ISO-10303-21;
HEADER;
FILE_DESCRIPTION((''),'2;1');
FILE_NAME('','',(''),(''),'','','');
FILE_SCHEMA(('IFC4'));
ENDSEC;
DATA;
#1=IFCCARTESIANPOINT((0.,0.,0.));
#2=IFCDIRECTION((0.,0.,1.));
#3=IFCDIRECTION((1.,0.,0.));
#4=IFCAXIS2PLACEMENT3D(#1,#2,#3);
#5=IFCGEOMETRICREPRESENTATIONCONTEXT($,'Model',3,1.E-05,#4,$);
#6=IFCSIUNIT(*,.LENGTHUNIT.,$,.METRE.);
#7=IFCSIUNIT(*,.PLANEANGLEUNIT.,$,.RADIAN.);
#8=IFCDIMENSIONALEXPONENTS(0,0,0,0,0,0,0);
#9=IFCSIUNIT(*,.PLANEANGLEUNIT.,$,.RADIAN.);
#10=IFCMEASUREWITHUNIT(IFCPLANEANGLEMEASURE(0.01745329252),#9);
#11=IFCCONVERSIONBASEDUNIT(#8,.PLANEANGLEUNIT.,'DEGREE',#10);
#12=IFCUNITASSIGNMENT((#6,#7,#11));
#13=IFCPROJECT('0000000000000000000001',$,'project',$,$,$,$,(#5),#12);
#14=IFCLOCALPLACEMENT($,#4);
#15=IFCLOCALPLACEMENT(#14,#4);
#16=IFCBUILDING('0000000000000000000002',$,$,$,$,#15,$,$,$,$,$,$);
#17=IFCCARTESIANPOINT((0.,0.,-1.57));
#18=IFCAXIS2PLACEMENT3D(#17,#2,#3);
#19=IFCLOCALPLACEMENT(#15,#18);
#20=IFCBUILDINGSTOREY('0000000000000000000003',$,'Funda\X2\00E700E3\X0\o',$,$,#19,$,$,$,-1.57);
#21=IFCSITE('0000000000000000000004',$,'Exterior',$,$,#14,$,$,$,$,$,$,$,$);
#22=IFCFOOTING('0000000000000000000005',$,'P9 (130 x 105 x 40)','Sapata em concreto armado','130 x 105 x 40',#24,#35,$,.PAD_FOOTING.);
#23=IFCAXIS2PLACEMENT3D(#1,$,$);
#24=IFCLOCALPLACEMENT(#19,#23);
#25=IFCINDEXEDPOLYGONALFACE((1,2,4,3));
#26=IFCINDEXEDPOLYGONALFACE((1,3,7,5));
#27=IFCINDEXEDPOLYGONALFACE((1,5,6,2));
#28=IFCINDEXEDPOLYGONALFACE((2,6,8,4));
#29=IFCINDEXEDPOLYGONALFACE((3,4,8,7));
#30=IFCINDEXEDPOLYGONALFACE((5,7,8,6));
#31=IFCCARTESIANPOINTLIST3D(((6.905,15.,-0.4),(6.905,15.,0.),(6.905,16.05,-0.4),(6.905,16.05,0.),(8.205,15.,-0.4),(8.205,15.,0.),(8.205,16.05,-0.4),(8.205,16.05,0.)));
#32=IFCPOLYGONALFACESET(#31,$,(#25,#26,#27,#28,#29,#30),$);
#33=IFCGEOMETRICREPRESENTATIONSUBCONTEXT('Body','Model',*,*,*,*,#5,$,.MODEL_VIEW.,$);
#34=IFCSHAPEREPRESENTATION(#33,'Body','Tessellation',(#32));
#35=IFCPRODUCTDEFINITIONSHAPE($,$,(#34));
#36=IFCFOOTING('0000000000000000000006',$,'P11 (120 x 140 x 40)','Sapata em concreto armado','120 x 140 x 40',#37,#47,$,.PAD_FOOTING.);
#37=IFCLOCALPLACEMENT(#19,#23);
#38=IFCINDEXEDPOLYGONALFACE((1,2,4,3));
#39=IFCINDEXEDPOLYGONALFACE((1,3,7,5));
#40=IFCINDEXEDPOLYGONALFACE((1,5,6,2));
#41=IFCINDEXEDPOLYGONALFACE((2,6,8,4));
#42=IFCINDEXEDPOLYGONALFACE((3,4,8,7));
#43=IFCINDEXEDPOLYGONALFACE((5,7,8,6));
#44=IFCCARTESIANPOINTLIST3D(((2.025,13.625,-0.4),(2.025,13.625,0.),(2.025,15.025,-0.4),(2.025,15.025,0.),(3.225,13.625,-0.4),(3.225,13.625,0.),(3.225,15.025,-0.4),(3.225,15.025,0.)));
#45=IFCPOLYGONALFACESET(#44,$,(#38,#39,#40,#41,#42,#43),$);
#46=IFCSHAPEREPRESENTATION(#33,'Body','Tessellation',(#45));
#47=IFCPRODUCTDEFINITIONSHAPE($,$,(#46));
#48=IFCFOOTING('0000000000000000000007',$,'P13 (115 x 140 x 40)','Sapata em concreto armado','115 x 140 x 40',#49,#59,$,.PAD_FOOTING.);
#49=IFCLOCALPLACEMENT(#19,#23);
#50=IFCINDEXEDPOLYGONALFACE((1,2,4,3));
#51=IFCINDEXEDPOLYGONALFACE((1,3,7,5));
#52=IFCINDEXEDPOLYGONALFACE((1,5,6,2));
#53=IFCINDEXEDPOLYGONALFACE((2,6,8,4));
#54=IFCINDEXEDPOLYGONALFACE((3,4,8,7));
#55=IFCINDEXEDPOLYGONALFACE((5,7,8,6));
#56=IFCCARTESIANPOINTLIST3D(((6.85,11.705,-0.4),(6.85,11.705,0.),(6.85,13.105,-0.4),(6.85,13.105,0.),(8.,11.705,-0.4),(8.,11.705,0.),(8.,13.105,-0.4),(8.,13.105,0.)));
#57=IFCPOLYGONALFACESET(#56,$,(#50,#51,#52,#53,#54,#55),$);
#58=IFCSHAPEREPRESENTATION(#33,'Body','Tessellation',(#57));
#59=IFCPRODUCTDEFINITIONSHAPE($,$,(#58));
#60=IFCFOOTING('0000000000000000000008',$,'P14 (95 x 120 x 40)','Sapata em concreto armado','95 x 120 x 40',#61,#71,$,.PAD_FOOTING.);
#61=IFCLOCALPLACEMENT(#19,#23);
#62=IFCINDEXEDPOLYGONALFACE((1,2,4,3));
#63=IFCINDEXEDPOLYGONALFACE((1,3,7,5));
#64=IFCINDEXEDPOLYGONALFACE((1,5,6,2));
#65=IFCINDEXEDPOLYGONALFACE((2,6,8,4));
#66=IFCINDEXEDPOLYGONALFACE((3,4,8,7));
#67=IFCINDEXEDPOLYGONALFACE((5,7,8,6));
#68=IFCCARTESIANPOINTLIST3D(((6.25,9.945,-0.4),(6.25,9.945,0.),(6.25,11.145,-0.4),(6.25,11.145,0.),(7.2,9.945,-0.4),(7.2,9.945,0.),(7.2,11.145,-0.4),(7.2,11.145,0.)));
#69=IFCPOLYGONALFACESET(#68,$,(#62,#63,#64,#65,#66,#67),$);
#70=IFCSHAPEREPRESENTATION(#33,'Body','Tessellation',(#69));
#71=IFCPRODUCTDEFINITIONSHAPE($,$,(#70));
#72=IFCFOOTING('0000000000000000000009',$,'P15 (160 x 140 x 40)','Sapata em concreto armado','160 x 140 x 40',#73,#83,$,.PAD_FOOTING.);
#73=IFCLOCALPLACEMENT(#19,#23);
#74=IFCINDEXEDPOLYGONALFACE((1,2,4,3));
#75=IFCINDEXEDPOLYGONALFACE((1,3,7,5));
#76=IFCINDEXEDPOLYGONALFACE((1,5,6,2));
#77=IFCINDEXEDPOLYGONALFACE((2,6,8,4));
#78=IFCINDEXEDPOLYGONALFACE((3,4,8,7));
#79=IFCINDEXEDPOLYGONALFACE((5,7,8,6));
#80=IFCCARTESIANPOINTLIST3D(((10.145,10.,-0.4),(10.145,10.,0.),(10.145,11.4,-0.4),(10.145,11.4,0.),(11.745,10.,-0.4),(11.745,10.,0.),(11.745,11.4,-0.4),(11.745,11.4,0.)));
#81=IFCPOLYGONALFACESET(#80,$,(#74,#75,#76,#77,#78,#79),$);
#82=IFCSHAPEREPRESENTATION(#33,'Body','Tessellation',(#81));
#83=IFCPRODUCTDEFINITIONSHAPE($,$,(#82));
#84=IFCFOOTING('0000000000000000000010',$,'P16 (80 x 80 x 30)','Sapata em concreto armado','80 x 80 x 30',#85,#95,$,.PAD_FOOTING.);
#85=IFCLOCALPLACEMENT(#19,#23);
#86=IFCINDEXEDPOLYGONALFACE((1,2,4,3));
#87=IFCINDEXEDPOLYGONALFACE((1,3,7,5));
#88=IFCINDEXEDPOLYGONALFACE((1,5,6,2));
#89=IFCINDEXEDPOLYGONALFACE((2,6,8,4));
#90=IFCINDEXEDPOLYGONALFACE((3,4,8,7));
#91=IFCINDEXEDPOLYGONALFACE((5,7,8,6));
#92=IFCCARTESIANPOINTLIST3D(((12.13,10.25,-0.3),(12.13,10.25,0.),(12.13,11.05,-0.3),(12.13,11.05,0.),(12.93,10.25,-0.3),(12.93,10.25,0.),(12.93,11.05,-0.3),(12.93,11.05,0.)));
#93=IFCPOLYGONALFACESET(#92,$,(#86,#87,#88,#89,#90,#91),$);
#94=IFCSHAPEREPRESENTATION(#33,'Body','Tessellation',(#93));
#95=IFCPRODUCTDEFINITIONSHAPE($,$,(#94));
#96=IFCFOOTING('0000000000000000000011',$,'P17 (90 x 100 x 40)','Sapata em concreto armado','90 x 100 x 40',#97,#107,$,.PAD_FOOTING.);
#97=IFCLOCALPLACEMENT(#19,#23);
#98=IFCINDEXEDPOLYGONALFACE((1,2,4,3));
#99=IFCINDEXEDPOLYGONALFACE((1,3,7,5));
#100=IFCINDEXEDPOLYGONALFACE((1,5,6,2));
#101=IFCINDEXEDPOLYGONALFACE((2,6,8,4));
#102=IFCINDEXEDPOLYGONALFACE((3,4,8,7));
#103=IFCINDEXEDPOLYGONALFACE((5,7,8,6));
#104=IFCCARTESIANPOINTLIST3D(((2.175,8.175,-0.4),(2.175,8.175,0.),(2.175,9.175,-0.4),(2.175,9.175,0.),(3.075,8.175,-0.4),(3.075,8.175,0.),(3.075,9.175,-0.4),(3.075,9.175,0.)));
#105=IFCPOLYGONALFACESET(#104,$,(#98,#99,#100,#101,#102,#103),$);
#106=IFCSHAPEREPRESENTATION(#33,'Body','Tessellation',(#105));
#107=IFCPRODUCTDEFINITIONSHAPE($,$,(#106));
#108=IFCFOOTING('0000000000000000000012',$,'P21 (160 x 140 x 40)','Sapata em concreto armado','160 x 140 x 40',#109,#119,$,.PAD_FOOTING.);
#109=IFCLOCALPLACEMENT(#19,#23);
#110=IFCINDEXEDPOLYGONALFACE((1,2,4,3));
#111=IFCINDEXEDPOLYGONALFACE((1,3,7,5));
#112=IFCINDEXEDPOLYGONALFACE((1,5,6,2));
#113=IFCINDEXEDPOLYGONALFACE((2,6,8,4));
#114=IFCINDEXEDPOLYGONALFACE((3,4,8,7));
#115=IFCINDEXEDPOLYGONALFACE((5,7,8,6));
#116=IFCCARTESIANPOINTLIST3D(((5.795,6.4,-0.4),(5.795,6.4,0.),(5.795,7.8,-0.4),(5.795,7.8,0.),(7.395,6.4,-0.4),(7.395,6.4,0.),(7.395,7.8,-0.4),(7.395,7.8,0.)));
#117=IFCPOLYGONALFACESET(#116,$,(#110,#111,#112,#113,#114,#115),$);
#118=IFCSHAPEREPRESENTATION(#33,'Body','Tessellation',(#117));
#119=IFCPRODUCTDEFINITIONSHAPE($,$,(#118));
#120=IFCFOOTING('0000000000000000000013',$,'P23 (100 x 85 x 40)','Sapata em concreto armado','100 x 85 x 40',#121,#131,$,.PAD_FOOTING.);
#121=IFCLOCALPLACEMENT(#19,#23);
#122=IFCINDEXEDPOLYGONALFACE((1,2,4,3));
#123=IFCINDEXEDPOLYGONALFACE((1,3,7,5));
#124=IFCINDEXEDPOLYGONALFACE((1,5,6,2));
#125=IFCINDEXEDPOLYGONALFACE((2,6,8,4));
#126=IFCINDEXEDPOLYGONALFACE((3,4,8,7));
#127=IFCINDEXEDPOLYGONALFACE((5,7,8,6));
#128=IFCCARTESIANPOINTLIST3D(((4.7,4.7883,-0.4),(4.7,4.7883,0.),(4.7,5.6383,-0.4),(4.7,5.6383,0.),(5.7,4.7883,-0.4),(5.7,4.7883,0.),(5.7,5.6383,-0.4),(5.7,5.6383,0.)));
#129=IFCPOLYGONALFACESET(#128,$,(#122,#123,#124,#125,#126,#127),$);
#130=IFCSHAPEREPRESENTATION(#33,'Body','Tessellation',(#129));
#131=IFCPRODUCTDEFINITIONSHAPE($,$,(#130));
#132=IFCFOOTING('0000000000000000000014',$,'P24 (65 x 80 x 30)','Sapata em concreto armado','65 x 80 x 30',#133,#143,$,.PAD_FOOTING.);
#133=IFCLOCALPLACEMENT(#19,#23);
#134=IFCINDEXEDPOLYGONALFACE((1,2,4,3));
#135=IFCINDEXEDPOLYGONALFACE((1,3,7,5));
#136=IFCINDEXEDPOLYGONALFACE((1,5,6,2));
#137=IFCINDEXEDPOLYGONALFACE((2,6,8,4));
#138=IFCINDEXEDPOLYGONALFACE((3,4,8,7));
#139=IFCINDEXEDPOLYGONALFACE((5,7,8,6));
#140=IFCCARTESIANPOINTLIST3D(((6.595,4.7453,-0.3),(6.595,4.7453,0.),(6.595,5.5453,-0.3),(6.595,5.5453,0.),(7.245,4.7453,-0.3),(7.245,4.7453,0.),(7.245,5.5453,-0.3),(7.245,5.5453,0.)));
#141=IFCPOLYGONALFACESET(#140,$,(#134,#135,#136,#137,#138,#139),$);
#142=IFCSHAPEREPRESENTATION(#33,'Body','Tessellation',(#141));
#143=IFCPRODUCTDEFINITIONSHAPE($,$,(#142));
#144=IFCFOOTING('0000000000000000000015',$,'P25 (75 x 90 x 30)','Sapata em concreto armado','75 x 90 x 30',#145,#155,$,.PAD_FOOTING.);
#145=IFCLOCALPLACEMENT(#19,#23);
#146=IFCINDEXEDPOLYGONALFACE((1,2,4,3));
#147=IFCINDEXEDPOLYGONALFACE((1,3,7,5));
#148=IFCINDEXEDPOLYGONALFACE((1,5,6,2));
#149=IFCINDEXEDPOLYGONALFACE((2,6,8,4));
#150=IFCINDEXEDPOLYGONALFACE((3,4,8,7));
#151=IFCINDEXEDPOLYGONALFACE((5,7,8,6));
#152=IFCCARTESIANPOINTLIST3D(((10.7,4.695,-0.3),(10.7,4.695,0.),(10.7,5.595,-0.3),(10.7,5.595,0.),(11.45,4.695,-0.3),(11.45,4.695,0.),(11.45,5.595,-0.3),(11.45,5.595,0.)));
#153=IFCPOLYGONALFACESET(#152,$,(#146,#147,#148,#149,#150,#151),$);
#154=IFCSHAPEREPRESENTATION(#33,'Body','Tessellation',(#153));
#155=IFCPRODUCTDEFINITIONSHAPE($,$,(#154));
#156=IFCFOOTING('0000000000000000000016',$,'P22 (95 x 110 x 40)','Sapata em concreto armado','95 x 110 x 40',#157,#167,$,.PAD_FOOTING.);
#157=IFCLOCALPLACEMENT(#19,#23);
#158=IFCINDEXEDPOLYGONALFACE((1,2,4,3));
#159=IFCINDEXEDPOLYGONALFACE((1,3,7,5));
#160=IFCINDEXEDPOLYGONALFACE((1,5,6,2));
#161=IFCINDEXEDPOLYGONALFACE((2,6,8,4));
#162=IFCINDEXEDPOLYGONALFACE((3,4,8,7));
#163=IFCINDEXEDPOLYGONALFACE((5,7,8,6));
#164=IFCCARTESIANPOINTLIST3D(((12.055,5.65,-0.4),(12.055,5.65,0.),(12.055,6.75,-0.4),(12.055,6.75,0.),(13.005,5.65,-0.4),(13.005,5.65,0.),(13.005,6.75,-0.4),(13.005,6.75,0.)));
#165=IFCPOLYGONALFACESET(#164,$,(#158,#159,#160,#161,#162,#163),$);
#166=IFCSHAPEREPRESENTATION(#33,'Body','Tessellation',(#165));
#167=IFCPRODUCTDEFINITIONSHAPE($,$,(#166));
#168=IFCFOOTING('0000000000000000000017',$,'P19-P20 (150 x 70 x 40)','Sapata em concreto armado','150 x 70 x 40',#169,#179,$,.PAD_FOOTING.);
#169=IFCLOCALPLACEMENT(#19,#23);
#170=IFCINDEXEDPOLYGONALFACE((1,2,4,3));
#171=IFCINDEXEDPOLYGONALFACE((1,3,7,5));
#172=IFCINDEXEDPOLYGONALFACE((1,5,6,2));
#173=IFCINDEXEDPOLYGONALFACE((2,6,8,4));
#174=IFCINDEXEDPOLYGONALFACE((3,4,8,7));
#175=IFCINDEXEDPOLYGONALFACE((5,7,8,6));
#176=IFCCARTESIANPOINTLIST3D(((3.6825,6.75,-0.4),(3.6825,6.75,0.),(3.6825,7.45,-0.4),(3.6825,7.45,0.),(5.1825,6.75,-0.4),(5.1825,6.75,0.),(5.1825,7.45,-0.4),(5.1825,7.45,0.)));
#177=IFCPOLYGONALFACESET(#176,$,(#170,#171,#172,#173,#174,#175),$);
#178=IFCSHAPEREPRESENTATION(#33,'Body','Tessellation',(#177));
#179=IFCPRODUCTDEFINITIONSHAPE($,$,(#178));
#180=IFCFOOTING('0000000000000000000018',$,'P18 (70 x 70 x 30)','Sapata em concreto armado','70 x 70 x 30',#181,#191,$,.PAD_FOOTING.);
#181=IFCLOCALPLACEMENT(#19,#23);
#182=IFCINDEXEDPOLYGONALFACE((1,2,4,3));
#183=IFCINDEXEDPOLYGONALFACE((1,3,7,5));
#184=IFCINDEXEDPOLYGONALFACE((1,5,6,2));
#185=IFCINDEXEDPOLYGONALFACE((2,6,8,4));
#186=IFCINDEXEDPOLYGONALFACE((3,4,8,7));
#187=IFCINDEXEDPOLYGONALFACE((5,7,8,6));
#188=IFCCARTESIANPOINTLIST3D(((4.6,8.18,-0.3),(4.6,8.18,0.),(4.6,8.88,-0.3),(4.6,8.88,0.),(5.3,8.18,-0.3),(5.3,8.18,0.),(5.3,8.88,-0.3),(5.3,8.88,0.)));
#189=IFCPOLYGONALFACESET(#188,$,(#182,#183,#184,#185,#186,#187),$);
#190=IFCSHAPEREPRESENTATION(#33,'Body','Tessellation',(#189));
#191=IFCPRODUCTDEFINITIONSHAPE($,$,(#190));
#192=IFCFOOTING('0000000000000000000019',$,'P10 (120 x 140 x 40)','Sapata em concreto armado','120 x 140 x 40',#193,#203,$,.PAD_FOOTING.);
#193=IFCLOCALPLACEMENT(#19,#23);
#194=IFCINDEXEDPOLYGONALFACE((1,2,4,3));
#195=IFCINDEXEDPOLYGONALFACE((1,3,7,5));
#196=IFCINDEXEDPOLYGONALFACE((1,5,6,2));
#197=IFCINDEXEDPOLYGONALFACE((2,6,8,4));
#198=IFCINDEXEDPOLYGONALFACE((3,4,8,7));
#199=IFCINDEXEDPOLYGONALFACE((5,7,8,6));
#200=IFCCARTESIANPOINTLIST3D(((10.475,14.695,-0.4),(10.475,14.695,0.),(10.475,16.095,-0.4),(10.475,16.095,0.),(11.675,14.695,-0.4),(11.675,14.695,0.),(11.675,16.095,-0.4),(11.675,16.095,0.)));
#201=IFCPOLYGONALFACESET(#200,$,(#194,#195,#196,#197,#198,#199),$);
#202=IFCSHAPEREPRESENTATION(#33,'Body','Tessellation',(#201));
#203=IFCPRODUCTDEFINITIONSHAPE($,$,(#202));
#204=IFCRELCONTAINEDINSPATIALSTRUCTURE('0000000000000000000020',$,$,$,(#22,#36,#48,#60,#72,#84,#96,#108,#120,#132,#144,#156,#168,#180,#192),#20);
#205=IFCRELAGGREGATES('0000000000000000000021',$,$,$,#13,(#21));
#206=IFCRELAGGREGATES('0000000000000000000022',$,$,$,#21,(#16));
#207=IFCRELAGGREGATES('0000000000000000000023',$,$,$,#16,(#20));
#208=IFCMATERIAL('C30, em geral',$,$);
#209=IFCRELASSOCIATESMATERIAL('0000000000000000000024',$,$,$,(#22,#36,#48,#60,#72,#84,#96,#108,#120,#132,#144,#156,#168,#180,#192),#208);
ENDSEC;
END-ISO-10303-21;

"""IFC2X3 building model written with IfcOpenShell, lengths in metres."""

from ifc_helpers import new_model, entity, si_unit, converted_unit, frame, origin_with_axes, origin_2d_with_axis, place, context, subcontext, project, spatial, rectangle, extrude, material, element, save


model = new_model("IFC2X3")

# Units and contexts
model_context = context("Model", 3, precision=1e-05, world=origin_with_axes())
body_context = subcontext(model_context, "Body", "Model", "MODEL_VIEW")
ifc_project = project(units=[si_unit("LENGTHUNIT", "METRE"), si_unit("PLANEANGLEUNIT", "RADIAN"), converted_unit("PLANEANGLEUNIT", "DEGREE", entity("IfcPlaneAngleMeasure", 0.01745329252), si_unit("PLANEANGLEUNIT", "RADIAN"), dimensions=[0, 0, 0, 0, 0, 0, 0])], contexts=[model_context])

# Site, building, storey
site_placement = place(None, origin_with_axes())
site = spatial("IfcSite", under=ifc_project, at=site_placement, Name="Exterior")
building_placement = place(site_placement, origin_with_axes())
building = spatial("IfcBuilding", under=site, at=building_placement)
storey_placement = place(building_placement, frame((0.0, 0.0, -1.57), z_axis=(0.0, 0.0, 1.0), x_axis=(1.0, 0.0, 0.0)))
storey = spatial("IfcBuildingStorey", under=building, at=storey_placement, Name="Fundação", Elevation=-1.57)

# Footings
ifc_material_1 = material(Name="C30, em geral")
footing_1_placement = place(storey_placement, frame((7.555, 15.525, -0.4), z_axis=(0.0, 0.0, 1.0), x_axis=(1.0, 0.0, 0.0)))
element("IfcFooting", 1, at=footing_1_placement, inside=storey, material=ifc_material_1, Name="P9 (130 x 105 x 40)", Description="Sapata em concreto armado", ObjectType="130 x 105 x 40", PredefinedType="PAD_FOOTING", context=body_context, shape_type="SweptSolid", body=[
    extrude(rectangle(XDim=1.3, YDim=1.05, at=origin_2d_with_axis()), origin_with_axes(), (0.0, 0.0, 1.0), 0.4),
])
footing_2_placement = place(storey_placement, frame((2.625, 14.325, -0.4), z_axis=(0.0, 0.0, 1.0), x_axis=(1.0, 0.0, 0.0)))
element("IfcFooting", 2, at=footing_2_placement, inside=storey, material=ifc_material_1, Name="P11 (120 x 140 x 40)", Description="Sapata em concreto armado", ObjectType="120 x 140 x 40", PredefinedType="PAD_FOOTING", context=body_context, shape_type="SweptSolid", body=[
    extrude(rectangle(XDim=1.2, YDim=1.4, at=origin_2d_with_axis()), origin_with_axes(), (0.0, 0.0, 1.0), 0.4),
])
footing_3_placement = place(storey_placement, frame((7.425, 12.405, -0.4), z_axis=(0.0, 0.0, 1.0), x_axis=(1.0, 0.0, 0.0)))
element("IfcFooting", 3, at=footing_3_placement, inside=storey, material=ifc_material_1, Name="P13 (115 x 140 x 40)", Description="Sapata em concreto armado", ObjectType="115 x 140 x 40", PredefinedType="PAD_FOOTING", context=body_context, shape_type="SweptSolid", body=[
    extrude(rectangle(XDim=1.15, YDim=1.4, at=origin_2d_with_axis()), origin_with_axes(), (0.0, 0.0, 1.0), 0.4),
])
footing_4_placement = place(storey_placement, frame((6.725, 10.545, -0.4), z_axis=(0.0, 0.0, 1.0), x_axis=(1.0, 0.0, 0.0)))
element("IfcFooting", 4, at=footing_4_placement, inside=storey, material=ifc_material_1, Name="P14 (95 x 120 x 40)", Description="Sapata em concreto armado", ObjectType="95 x 120 x 40", PredefinedType="PAD_FOOTING", context=body_context, shape_type="SweptSolid", body=[
    extrude(rectangle(XDim=0.95, YDim=1.2, at=origin_2d_with_axis()), origin_with_axes(), (0.0, 0.0, 1.0), 0.4),
])
footing_5_placement = place(storey_placement, frame((10.945, 10.7, -0.4), z_axis=(0.0, 0.0, 1.0), x_axis=(1.0, 0.0, 0.0)))
element("IfcFooting", 5, at=footing_5_placement, inside=storey, material=ifc_material_1, Name="P15 (160 x 140 x 40)", Description="Sapata em concreto armado", ObjectType="160 x 140 x 40", PredefinedType="PAD_FOOTING", context=body_context, shape_type="SweptSolid", body=[
    extrude(rectangle(XDim=1.6, YDim=1.4, at=origin_2d_with_axis()), origin_with_axes(), (0.0, 0.0, 1.0), 0.4),
])
footing_6_placement = place(storey_placement, frame((12.53, 10.65, -0.3), z_axis=(0.0, 0.0, 1.0), x_axis=(1.0, 0.0, 0.0)))
element("IfcFooting", 6, at=footing_6_placement, inside=storey, material=ifc_material_1, Name="P16 (80 x 80 x 30)", Description="Sapata em concreto armado", ObjectType="80 x 80 x 30", PredefinedType="PAD_FOOTING", context=body_context, shape_type="SweptSolid", body=[
    extrude(rectangle(XDim=0.8, YDim=0.8, at=origin_2d_with_axis()), origin_with_axes(), (0.0, 0.0, 1.0), 0.3),
])
footing_7_placement = place(storey_placement, frame((2.625, 8.675, -0.4), z_axis=(0.0, 0.0, 1.0), x_axis=(1.0, 0.0, 0.0)))
element("IfcFooting", 7, at=footing_7_placement, inside=storey, material=ifc_material_1, Name="P17 (90 x 100 x 40)", Description="Sapata em concreto armado", ObjectType="90 x 100 x 40", PredefinedType="PAD_FOOTING", context=body_context, shape_type="SweptSolid", body=[
    extrude(rectangle(XDim=0.9, YDim=1.0, at=origin_2d_with_axis()), origin_with_axes(), (0.0, 0.0, 1.0), 0.4),
])
footing_8_placement = place(storey_placement, frame((6.595, 7.1, -0.4), z_axis=(0.0, 0.0, 1.0), x_axis=(1.0, 0.0, 0.0)))
element("IfcFooting", 8, at=footing_8_placement, inside=storey, material=ifc_material_1, Name="P21 (160 x 140 x 40)", Description="Sapata em concreto armado", ObjectType="160 x 140 x 40", PredefinedType="PAD_FOOTING", context=body_context, shape_type="SweptSolid", body=[
    extrude(rectangle(XDim=1.6, YDim=1.4, at=origin_2d_with_axis()), origin_with_axes(), (0.0, 0.0, 1.0), 0.4),
])
footing_9_placement = place(storey_placement, frame((5.2, 5.2133, -0.4), z_axis=(0.0, 0.0, 1.0), x_axis=(1.0, 0.0, 0.0)))
element("IfcFooting", 9, at=footing_9_placement, inside=storey, material=ifc_material_1, Name="P23 (100 x 85 x 40)", Description="Sapata em concreto armado", ObjectType="100 x 85 x 40", PredefinedType="PAD_FOOTING", context=body_context, shape_type="SweptSolid", body=[
    extrude(rectangle(XDim=1.0, YDim=0.85, at=origin_2d_with_axis()), origin_with_axes(), (0.0, 0.0, 1.0), 0.4),
])
footing_10_placement = place(storey_placement, frame((6.92, 5.1453, -0.3), z_axis=(0.0, 0.0, 1.0), x_axis=(1.0, 0.0, 0.0)))
element("IfcFooting", 10, at=footing_10_placement, inside=storey, material=ifc_material_1, Name="P24 (65 x 80 x 30)", Description="Sapata em concreto armado", ObjectType="65 x 80 x 30", PredefinedType="PAD_FOOTING", context=body_context, shape_type="SweptSolid", body=[
    extrude(rectangle(XDim=0.65, YDim=0.8, at=origin_2d_with_axis()), origin_with_axes(), (0.0, 0.0, 1.0), 0.3),
])
footing_11_placement = place(storey_placement, frame((11.075, 5.145, -0.3), z_axis=(0.0, 0.0, 1.0), x_axis=(1.0, 0.0, 0.0)))
element("IfcFooting", 11, at=footing_11_placement, inside=storey, material=ifc_material_1, Name="P25 (75 x 90 x 30)", Description="Sapata em concreto armado", ObjectType="75 x 90 x 30", PredefinedType="PAD_FOOTING", context=body_context, shape_type="SweptSolid", body=[
    extrude(rectangle(XDim=0.75, YDim=0.9, at=origin_2d_with_axis()), origin_with_axes(), (0.0, 0.0, 1.0), 0.3),
])
footing_12_placement = place(storey_placement, frame((12.53, 6.2, -0.4), z_axis=(0.0, 0.0, 1.0), x_axis=(1.0, 0.0, 0.0)))
element("IfcFooting", 12, at=footing_12_placement, inside=storey, material=ifc_material_1, Name="P22 (95 x 110 x 40)", Description="Sapata em concreto armado", ObjectType="95 x 110 x 40", PredefinedType="PAD_FOOTING", context=body_context, shape_type="SweptSolid", body=[
    extrude(rectangle(XDim=0.95, YDim=1.1, at=origin_2d_with_axis()), origin_with_axes(), (0.0, 0.0, 1.0), 0.4),
])
footing_13_placement = place(storey_placement, frame((4.4325, 7.1, -0.4), z_axis=(0.0, 0.0, 1.0), x_axis=(1.0, 0.0, 0.0)))
element("IfcFooting", 13, at=footing_13_placement, inside=storey, material=ifc_material_1, Name="P19-P20 (150 x 70 x 40)", Description="Sapata em concreto armado", ObjectType="150 x 70 x 40", PredefinedType="PAD_FOOTING", context=body_context, shape_type="SweptSolid", body=[
    extrude(rectangle(XDim=1.5, YDim=0.7, at=origin_2d_with_axis()), origin_with_axes(), (0.0, 0.0, 1.0), 0.4),
])
footing_14_placement = place(storey_placement, frame((4.95, 8.53, -0.3), z_axis=(0.0, 0.0, 1.0), x_axis=(1.0, 0.0, 0.0)))
element("IfcFooting", 14, at=footing_14_placement, inside=storey, material=ifc_material_1, Name="P18 (70 x 70 x 30)", Description="Sapata em concreto armado", ObjectType="70 x 70 x 30", PredefinedType="PAD_FOOTING", context=body_context, shape_type="SweptSolid", body=[
    extrude(rectangle(XDim=0.7, YDim=0.7, at=origin_2d_with_axis()), origin_with_axes(), (0.0, 0.0, 1.0), 0.3),
])
footing_15_placement = place(storey_placement, frame((11.075, 15.395, -0.4), z_axis=(0.0, 0.0, 1.0), x_axis=(1.0, 0.0, 0.0)))
element("IfcFooting", 15, at=footing_15_placement, inside=storey, material=ifc_material_1, Name="P10 (120 x 140 x 40)", Description="Sapata em concreto armado", ObjectType="120 x 140 x 40", PredefinedType="PAD_FOOTING", context=body_context, shape_type="SweptSolid", body=[
    extrude(rectangle(XDim=1.2, YDim=1.4, at=origin_2d_with_axis()), origin_with_axes(), (0.0, 0.0, 1.0), 0.4),
])

save(model, "model.ifc")
